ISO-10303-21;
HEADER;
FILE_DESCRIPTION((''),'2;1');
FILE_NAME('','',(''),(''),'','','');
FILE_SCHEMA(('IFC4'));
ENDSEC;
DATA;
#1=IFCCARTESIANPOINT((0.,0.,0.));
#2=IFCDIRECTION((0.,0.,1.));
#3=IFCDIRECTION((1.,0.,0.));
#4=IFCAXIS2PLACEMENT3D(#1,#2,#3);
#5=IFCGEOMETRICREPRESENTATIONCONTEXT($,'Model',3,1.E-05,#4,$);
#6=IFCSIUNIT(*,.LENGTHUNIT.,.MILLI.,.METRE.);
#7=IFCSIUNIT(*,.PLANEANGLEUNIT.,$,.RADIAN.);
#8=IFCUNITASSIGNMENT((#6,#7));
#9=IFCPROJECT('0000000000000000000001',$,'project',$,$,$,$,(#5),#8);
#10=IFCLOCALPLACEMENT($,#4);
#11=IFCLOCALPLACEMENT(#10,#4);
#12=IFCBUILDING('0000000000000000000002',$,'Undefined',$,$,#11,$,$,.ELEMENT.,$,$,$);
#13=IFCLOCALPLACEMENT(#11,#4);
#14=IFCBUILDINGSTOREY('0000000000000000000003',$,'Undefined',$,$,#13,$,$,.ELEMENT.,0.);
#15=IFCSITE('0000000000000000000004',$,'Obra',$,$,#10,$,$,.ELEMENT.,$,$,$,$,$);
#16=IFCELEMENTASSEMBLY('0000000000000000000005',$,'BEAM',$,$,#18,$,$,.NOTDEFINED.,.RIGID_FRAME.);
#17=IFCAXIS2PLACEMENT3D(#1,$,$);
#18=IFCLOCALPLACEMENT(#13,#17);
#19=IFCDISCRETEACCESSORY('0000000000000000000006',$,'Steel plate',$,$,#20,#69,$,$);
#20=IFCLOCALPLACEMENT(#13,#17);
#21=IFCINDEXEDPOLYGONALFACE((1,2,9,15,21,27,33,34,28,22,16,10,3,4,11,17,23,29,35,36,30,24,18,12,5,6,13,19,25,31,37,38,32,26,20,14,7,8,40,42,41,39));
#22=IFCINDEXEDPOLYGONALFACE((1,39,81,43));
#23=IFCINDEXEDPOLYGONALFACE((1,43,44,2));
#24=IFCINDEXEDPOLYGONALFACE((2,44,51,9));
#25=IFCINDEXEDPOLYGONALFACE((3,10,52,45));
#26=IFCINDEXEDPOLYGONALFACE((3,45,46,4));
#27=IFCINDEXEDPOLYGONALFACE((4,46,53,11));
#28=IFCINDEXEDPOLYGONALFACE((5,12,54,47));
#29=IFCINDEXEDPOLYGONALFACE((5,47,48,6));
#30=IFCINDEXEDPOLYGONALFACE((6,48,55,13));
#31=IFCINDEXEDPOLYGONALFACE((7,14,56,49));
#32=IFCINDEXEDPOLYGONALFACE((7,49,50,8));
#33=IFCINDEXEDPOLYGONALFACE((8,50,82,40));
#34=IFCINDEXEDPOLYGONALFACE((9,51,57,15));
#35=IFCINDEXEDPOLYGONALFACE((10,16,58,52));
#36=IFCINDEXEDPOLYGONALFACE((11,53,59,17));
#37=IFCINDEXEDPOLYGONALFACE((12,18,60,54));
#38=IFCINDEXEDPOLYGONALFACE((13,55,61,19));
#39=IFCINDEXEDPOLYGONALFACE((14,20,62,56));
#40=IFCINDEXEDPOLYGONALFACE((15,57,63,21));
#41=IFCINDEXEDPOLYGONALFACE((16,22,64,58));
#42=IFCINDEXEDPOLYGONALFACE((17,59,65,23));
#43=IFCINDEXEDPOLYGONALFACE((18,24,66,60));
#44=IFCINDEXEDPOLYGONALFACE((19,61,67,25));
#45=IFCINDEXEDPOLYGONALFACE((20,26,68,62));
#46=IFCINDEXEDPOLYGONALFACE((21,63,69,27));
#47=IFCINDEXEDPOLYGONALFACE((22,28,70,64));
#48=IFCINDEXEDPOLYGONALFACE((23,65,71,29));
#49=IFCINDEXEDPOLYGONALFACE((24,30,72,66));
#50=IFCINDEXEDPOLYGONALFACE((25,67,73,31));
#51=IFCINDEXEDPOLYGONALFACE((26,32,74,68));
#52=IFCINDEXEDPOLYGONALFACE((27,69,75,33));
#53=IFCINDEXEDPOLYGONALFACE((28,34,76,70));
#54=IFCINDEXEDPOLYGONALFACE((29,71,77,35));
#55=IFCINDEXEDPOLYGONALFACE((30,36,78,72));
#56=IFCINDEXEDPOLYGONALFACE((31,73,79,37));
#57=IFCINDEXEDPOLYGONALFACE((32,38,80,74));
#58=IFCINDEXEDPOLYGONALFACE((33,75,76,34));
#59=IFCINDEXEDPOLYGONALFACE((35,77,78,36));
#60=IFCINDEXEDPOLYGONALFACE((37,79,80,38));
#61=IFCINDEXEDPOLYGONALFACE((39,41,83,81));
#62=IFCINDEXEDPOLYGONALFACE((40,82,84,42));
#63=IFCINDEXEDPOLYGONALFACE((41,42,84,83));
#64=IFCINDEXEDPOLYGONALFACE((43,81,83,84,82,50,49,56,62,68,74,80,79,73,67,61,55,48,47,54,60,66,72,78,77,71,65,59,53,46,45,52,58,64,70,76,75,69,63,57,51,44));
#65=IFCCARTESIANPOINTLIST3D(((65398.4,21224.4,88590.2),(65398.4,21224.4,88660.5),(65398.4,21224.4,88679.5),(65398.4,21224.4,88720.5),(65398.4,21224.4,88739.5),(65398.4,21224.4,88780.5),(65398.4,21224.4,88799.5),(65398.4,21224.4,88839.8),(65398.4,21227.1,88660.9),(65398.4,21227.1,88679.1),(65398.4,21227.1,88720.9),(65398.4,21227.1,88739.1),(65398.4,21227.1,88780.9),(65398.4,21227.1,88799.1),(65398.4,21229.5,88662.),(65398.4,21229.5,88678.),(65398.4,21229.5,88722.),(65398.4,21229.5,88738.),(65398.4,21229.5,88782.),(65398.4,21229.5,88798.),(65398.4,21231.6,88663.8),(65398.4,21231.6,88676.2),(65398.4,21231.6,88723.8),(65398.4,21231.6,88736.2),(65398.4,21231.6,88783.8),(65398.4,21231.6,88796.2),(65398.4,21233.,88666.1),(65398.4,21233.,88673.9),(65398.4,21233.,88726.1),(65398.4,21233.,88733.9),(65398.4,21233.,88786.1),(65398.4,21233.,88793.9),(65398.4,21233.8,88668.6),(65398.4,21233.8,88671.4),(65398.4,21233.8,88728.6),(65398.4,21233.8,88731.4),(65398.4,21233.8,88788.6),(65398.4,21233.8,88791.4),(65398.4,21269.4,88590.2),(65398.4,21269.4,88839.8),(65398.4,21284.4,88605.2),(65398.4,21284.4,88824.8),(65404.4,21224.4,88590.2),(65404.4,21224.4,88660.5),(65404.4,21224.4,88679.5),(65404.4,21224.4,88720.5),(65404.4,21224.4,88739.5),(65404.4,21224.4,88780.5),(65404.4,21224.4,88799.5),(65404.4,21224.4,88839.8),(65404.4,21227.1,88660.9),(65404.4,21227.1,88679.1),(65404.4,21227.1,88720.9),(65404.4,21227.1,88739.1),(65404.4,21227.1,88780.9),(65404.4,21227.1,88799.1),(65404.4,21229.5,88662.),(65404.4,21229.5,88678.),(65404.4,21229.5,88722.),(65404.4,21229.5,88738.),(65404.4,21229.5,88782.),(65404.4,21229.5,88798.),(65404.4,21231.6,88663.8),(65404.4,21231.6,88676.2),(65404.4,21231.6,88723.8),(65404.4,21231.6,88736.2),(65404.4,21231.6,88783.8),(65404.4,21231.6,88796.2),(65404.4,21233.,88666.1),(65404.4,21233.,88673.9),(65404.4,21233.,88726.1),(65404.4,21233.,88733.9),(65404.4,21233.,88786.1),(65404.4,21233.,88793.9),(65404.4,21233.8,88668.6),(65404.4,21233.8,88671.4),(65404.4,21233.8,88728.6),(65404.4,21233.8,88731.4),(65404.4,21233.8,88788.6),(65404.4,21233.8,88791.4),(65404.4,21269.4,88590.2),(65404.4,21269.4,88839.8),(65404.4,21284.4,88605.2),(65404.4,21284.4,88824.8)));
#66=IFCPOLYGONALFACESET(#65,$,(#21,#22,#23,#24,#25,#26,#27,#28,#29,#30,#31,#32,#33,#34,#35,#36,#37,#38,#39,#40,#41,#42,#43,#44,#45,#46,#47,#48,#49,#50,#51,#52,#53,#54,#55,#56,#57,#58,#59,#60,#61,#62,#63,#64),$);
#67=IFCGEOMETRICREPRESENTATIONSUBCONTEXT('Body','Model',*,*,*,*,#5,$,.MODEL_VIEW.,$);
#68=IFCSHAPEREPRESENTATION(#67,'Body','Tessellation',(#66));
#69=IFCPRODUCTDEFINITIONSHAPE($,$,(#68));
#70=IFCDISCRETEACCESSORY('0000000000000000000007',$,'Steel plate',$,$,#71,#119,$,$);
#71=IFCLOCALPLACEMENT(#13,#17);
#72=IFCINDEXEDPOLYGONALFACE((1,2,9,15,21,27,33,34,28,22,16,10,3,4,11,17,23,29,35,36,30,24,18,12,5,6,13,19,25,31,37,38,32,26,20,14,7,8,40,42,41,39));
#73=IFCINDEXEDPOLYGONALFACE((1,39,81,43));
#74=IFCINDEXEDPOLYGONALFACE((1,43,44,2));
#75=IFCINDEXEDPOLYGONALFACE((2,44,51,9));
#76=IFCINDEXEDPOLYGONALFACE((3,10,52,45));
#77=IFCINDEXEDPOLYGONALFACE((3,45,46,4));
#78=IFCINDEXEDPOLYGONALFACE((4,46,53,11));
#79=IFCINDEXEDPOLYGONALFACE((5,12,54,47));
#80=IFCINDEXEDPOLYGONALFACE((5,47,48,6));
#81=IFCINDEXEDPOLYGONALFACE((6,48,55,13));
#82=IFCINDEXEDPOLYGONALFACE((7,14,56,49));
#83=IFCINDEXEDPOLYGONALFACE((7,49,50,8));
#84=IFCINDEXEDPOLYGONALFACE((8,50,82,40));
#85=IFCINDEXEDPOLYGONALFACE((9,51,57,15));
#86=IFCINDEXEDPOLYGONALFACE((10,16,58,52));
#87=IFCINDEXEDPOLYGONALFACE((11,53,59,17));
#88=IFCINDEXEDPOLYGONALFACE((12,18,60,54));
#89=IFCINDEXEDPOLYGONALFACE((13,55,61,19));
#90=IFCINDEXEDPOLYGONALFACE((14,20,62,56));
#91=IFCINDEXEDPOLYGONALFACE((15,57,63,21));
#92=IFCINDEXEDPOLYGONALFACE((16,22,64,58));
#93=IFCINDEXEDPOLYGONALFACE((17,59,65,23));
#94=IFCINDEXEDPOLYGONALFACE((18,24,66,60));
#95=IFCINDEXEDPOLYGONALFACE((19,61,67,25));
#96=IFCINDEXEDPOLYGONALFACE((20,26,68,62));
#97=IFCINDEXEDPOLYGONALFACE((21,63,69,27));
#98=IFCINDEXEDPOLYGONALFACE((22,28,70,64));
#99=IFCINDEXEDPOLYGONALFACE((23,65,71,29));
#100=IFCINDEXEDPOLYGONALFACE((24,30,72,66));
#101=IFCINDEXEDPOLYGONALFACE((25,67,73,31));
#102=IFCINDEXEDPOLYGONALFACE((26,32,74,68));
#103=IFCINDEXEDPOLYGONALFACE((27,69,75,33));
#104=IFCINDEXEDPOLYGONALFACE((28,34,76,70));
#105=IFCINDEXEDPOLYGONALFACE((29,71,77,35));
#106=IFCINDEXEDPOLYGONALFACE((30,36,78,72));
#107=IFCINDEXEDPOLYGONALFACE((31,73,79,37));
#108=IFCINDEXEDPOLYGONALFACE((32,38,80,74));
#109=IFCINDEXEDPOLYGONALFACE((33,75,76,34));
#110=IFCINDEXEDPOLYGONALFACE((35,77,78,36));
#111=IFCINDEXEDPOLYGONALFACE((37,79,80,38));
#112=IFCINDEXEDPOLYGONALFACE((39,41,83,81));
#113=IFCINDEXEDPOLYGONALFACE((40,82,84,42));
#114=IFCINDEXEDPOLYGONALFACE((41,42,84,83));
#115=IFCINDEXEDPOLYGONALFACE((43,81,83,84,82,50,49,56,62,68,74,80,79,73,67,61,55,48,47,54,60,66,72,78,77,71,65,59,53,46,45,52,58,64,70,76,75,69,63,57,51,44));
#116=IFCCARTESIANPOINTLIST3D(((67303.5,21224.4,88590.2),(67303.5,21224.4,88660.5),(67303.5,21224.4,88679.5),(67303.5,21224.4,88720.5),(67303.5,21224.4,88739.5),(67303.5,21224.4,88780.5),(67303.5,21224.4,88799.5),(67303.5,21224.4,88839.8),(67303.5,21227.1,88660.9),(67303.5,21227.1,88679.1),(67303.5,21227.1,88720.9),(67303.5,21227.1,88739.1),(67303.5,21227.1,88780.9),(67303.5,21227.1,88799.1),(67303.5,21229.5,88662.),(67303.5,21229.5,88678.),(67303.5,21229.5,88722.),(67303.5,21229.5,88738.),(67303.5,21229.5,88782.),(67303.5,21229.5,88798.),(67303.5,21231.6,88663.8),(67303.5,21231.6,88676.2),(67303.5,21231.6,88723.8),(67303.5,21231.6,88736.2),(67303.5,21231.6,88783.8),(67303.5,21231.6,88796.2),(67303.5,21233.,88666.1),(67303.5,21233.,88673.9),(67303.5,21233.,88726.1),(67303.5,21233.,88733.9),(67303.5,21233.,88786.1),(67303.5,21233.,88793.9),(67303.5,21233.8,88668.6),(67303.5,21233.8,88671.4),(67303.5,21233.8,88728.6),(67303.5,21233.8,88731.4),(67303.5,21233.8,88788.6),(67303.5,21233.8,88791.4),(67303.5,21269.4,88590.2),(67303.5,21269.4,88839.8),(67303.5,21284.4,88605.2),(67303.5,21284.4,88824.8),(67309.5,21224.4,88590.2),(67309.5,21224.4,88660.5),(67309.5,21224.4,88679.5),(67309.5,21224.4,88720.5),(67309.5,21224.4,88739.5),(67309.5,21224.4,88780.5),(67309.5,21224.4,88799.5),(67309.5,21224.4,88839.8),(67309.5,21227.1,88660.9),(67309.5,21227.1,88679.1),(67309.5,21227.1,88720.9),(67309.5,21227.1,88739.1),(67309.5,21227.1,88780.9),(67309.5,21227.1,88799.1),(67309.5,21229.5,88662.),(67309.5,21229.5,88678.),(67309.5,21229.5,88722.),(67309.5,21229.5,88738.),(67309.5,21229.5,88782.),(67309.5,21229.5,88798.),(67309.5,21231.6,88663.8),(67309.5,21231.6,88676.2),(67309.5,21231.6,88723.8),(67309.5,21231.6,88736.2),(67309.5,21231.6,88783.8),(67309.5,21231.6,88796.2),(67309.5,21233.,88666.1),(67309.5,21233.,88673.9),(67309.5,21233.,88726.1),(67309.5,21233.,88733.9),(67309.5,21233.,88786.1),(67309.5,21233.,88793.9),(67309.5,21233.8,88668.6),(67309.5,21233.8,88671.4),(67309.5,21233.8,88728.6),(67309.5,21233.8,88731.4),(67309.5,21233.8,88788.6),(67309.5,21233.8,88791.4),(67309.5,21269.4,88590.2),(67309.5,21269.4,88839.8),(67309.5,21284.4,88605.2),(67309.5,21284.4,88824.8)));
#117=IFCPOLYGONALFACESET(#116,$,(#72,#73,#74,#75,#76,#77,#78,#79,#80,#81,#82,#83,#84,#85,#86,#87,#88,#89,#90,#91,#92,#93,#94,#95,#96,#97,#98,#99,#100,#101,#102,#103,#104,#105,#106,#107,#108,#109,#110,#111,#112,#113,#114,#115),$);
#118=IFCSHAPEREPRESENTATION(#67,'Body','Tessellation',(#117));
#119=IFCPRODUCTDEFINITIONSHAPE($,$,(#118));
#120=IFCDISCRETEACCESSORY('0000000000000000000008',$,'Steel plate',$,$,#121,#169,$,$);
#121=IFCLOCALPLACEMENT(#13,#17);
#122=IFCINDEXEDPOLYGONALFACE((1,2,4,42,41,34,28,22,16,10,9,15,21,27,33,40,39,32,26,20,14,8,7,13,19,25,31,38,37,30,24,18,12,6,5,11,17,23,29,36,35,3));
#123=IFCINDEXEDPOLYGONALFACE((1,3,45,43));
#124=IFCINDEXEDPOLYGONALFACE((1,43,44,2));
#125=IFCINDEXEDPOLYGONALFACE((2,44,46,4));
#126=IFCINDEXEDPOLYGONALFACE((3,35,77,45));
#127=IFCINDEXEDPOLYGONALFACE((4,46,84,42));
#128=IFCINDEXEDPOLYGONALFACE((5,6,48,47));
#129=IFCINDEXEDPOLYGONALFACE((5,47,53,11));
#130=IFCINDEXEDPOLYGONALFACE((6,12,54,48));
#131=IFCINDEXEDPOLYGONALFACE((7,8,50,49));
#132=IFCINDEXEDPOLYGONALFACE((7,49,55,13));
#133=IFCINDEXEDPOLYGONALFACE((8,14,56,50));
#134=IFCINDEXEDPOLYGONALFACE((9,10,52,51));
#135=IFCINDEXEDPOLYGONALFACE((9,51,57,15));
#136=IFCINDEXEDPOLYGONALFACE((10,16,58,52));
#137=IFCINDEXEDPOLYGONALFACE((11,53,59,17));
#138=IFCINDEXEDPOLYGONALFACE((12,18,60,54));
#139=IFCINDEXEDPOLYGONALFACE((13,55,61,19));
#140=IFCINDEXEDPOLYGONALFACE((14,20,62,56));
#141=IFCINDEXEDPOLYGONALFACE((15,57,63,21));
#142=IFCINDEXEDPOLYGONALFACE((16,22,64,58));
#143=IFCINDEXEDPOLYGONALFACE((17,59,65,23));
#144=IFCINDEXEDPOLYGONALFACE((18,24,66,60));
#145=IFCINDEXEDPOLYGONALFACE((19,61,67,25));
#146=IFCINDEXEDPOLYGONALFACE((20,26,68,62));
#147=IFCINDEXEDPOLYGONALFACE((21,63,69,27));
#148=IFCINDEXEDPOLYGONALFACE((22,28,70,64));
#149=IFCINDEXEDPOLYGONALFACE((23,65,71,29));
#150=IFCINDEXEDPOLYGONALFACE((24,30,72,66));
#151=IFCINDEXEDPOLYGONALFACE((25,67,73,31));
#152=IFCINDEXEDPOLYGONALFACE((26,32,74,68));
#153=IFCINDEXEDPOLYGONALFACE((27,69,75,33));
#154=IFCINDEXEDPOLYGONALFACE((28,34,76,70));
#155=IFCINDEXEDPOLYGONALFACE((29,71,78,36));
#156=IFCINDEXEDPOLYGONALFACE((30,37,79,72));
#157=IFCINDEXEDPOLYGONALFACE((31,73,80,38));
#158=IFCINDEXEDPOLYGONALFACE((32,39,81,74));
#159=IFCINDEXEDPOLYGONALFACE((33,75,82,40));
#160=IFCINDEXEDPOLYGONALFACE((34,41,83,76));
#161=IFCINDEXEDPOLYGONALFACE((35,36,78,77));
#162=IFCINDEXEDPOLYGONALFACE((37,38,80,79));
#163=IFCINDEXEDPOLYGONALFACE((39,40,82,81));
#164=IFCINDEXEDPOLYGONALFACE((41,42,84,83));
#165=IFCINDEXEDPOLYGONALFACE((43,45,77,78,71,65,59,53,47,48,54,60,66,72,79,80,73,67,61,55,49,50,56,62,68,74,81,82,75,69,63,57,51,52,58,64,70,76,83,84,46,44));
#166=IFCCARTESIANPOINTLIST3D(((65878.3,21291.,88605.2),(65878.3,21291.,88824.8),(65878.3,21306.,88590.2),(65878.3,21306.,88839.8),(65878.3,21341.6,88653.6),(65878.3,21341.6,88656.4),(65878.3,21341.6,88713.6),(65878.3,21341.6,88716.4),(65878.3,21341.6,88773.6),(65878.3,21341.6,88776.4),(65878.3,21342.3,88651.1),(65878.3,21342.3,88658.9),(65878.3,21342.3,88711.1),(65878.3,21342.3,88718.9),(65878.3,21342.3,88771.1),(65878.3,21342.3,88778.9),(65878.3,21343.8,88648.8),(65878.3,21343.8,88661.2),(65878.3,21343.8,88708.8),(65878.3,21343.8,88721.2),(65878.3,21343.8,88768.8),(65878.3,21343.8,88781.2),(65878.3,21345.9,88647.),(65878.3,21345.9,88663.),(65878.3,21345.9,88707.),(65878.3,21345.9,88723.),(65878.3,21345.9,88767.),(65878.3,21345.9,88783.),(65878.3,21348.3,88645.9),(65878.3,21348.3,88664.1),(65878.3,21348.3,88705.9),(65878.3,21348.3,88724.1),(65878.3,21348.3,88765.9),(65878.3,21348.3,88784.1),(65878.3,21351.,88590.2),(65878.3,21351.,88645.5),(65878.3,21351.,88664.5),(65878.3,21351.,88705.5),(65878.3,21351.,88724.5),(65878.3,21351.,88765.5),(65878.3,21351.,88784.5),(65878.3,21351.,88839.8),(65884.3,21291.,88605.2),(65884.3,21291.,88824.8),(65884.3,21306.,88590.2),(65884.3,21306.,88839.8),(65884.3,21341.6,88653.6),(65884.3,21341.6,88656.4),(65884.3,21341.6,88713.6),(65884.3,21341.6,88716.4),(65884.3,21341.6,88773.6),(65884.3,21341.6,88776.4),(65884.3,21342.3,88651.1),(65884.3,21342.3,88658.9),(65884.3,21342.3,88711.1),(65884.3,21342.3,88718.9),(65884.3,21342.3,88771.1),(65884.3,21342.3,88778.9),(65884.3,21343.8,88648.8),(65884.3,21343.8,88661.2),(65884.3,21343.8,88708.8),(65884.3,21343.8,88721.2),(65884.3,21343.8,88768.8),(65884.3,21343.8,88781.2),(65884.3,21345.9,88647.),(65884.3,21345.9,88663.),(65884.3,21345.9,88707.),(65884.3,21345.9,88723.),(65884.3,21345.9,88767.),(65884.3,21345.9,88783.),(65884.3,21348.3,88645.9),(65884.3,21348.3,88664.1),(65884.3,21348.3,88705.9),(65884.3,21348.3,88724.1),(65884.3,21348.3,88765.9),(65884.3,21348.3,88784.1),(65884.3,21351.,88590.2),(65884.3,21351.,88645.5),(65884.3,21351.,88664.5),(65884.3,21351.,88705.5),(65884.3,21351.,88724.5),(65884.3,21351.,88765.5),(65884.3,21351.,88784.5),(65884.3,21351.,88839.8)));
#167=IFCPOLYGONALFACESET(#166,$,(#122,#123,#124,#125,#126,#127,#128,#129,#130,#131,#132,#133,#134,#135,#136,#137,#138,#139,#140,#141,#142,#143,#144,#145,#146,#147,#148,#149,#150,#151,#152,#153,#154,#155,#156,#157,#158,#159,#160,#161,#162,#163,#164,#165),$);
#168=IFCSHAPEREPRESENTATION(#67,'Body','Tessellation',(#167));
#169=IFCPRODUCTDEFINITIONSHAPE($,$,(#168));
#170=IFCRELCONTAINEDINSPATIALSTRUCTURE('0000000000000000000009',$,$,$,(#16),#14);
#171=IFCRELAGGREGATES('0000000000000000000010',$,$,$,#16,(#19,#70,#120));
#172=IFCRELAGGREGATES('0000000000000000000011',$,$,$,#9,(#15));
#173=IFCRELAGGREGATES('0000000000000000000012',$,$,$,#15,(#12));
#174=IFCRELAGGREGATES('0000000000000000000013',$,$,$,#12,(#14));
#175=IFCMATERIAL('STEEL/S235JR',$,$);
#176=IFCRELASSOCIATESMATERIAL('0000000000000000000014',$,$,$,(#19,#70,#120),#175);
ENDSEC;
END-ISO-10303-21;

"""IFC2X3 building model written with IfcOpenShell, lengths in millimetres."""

from ifc_helpers import new_model, si_unit, frame, origin_with_axes, origin_2d_with_axis, place, context, subcontext, project, spatial, polyline, circle, outline, extrude, source, transform, mapped, material, element, aggregate, save


model = new_model("IFC2X3")

# Units and contexts
model_context = context("Model", 3, precision=1e-05, world=origin_with_axes())
body_context = subcontext(model_context, "Body", "Model", "MODEL_VIEW")
ifc_project = project(units=[si_unit("LENGTHUNIT", "METRE", prefix="MILLI"), si_unit("PLANEANGLEUNIT", "RADIAN")], contexts=[model_context])

# Site, building, storey
site_placement = place(None, origin_with_axes())
site = spatial("IfcSite", under=ifc_project, at=site_placement, Name="Obra", CompositionType="ELEMENT")
building_placement = place(site_placement, origin_with_axes())
building = spatial("IfcBuilding", under=site, at=building_placement, Name="Undefined", CompositionType="ELEMENT")
storey_placement = place(building_placement, origin_with_axes())
storey = spatial("IfcBuildingStorey", under=building, at=storey_placement, Name="Undefined", CompositionType="ELEMENT", Elevation=0.0)

# Shared definitions
ifc_material = material(Name="STEEL/S235JR")

# Element assembly, discrete accessories, openings
shared_shape_1 = source(origin_with_axes(), body_context, "Body", "SweptSolid", [
    extrude(circle(Radius=9.5, at=origin_2d_with_axis()), frame((0.0, -9.2, 0.0), z_axis=(0.0, 1.0, 0.0), x_axis=(1.0, 0.0, 0.0)), (0.0, 0.0, 1.0), 6.2),
])
assembly_1_placement = place(storey_placement, origin_with_axes())
assembly_1 = element("IfcElementAssembly", 1, at=assembly_1_placement, inside=storey, Name="BEAM", AssemblyPlace="NOTDEFINED", PredefinedType="RIGID_FRAME")
discrete_accessory_1_placement = place(assembly_1_placement, frame((65401.4, 21224.4, 88590.2), z_axis=(1.0, 0.000001, 0.0), x_axis=(-0.000002, 1.0, 0.0)))
discrete_accessory_1 = element("IfcDiscreteAccessory", 2, at=discrete_accessory_1_placement, material=ifc_material, Name="Steel plate", context=body_context, shape_type="SweptSolid", body=[
    extrude(outline(polyline([(0.0, 0.0), (45.0, 0.0), (60.0, 15.0), (60.0, 234.6), (45.0, 249.6), (0.0, 249.6), (0.0, 0.0)])), frame((0.0, 0.0, -3.0), z_axis=(0.0, 0.0, 1.0), x_axis=(1.0, 0.0, 0.0)), (0.0, 0.0, 1.0), 6.0),
])
opening_1_placement = place(assembly_1_placement, frame((65407.5, 21274.4, 88850.0), z_axis=(0.000002, -1.0, 0.0), x_axis=(0.0, 0.0, -1.0)))
element("IfcOpeningElement", 3, at=opening_1_placement, cuts=discrete_accessory_1, ObjectType="Opening", context=body_context, shape_type="MappedRepresentation", body=[
    mapped(shared_shape_1, transform((60.0, 0.0, 50.0))),
    mapped(shared_shape_1, transform((120.0, 0.0, 50.0))),
    mapped(shared_shape_1, transform((180.0, 0.0, 50.0))),
])
discrete_accessory_2_placement = place(assembly_1_placement, frame((67306.5, 21224.4, 88590.2), z_axis=(1.0, 0.000001, 0.0), x_axis=(-0.000002, 1.0, 0.0)))
discrete_accessory_2 = element("IfcDiscreteAccessory", 4, at=discrete_accessory_2_placement, material=ifc_material, Name="Steel plate", context=body_context, shape_type="SweptSolid", body=[
    extrude(outline(polyline([(0.0, 0.0), (45.0, 0.0), (60.0, 15.0), (60.0, 234.6), (45.0, 249.6), (0.0, 249.6), (0.0, 0.0)])), frame((0.0, 0.0, -3.0), z_axis=(0.0, 0.0, 1.0), x_axis=(1.0, 0.0, 0.0)), (0.0, 0.0, 1.0), 6.0),
])
opening_2_placement = place(assembly_1_placement, frame((67312.6, 21274.4, 88850.0), z_axis=(0.000002, -1.0, 0.0), x_axis=(0.0, 0.0, -1.0)))
element("IfcOpeningElement", 5, at=opening_2_placement, cuts=discrete_accessory_2, ObjectType="Opening", context=body_context, shape_type="MappedRepresentation", body=[
    mapped(shared_shape_1, transform((60.0, 0.0, 50.0))),
    mapped(shared_shape_1, transform((120.0, 0.0, 50.0))),
    mapped(shared_shape_1, transform((180.0, 0.0, 50.0))),
])
discrete_accessory_3_placement = place(assembly_1_placement, frame((65881.3, 21351.0, 88590.2), z_axis=(-1.0, -0.000002, 0.0), x_axis=(0.000002, -1.0, 0.0)))
discrete_accessory_3 = element("IfcDiscreteAccessory", 6, at=discrete_accessory_3_placement, material=ifc_material, Name="Steel plate", context=body_context, shape_type="SweptSolid", body=[
    extrude(outline(polyline([(0.0, 0.0), (45.0, 0.0), (60.0, 15.0), (60.0, 234.6), (45.0, 249.6), (0.0, 249.6), (0.0, 0.0)])), frame((0.0, 0.0, -3.0), z_axis=(0.0, 0.0, 1.0), x_axis=(1.0, 0.0, 0.0)), (0.0, 0.0, 1.0), 6.0),
])
shared_shape_2 = source(origin_with_axes(), body_context, "Body", "SweptSolid", [
    extrude(circle(Radius=9.5, at=origin_2d_with_axis()), frame((0.0, -9.4, 0.0), z_axis=(0.0, 1.0, 0.0), x_axis=(1.0, 0.0, 0.0)), (0.0, 0.0, 1.0), 6.2),
])
opening_3_placement = place(assembly_1_placement, frame((65875.0, 21301.0, 88850.0), z_axis=(-0.000002, 1.0, 0.0), x_axis=(0.0, 0.0, -1.0)))
element("IfcOpeningElement", 7, at=opening_3_placement, cuts=discrete_accessory_3, ObjectType="Opening", context=body_context, shape_type="MappedRepresentation", body=[
    mapped(shared_shape_2, transform((75.0, 0.0, 50.0))),
    mapped(shared_shape_2, transform((135.0, 0.0, 50.0))),
    mapped(shared_shape_2, transform((195.0, 0.0, 50.0))),
])
aggregate(assembly_1, [discrete_accessory_1, discrete_accessory_2, discrete_accessory_3])

save(model, "model.ifc")
